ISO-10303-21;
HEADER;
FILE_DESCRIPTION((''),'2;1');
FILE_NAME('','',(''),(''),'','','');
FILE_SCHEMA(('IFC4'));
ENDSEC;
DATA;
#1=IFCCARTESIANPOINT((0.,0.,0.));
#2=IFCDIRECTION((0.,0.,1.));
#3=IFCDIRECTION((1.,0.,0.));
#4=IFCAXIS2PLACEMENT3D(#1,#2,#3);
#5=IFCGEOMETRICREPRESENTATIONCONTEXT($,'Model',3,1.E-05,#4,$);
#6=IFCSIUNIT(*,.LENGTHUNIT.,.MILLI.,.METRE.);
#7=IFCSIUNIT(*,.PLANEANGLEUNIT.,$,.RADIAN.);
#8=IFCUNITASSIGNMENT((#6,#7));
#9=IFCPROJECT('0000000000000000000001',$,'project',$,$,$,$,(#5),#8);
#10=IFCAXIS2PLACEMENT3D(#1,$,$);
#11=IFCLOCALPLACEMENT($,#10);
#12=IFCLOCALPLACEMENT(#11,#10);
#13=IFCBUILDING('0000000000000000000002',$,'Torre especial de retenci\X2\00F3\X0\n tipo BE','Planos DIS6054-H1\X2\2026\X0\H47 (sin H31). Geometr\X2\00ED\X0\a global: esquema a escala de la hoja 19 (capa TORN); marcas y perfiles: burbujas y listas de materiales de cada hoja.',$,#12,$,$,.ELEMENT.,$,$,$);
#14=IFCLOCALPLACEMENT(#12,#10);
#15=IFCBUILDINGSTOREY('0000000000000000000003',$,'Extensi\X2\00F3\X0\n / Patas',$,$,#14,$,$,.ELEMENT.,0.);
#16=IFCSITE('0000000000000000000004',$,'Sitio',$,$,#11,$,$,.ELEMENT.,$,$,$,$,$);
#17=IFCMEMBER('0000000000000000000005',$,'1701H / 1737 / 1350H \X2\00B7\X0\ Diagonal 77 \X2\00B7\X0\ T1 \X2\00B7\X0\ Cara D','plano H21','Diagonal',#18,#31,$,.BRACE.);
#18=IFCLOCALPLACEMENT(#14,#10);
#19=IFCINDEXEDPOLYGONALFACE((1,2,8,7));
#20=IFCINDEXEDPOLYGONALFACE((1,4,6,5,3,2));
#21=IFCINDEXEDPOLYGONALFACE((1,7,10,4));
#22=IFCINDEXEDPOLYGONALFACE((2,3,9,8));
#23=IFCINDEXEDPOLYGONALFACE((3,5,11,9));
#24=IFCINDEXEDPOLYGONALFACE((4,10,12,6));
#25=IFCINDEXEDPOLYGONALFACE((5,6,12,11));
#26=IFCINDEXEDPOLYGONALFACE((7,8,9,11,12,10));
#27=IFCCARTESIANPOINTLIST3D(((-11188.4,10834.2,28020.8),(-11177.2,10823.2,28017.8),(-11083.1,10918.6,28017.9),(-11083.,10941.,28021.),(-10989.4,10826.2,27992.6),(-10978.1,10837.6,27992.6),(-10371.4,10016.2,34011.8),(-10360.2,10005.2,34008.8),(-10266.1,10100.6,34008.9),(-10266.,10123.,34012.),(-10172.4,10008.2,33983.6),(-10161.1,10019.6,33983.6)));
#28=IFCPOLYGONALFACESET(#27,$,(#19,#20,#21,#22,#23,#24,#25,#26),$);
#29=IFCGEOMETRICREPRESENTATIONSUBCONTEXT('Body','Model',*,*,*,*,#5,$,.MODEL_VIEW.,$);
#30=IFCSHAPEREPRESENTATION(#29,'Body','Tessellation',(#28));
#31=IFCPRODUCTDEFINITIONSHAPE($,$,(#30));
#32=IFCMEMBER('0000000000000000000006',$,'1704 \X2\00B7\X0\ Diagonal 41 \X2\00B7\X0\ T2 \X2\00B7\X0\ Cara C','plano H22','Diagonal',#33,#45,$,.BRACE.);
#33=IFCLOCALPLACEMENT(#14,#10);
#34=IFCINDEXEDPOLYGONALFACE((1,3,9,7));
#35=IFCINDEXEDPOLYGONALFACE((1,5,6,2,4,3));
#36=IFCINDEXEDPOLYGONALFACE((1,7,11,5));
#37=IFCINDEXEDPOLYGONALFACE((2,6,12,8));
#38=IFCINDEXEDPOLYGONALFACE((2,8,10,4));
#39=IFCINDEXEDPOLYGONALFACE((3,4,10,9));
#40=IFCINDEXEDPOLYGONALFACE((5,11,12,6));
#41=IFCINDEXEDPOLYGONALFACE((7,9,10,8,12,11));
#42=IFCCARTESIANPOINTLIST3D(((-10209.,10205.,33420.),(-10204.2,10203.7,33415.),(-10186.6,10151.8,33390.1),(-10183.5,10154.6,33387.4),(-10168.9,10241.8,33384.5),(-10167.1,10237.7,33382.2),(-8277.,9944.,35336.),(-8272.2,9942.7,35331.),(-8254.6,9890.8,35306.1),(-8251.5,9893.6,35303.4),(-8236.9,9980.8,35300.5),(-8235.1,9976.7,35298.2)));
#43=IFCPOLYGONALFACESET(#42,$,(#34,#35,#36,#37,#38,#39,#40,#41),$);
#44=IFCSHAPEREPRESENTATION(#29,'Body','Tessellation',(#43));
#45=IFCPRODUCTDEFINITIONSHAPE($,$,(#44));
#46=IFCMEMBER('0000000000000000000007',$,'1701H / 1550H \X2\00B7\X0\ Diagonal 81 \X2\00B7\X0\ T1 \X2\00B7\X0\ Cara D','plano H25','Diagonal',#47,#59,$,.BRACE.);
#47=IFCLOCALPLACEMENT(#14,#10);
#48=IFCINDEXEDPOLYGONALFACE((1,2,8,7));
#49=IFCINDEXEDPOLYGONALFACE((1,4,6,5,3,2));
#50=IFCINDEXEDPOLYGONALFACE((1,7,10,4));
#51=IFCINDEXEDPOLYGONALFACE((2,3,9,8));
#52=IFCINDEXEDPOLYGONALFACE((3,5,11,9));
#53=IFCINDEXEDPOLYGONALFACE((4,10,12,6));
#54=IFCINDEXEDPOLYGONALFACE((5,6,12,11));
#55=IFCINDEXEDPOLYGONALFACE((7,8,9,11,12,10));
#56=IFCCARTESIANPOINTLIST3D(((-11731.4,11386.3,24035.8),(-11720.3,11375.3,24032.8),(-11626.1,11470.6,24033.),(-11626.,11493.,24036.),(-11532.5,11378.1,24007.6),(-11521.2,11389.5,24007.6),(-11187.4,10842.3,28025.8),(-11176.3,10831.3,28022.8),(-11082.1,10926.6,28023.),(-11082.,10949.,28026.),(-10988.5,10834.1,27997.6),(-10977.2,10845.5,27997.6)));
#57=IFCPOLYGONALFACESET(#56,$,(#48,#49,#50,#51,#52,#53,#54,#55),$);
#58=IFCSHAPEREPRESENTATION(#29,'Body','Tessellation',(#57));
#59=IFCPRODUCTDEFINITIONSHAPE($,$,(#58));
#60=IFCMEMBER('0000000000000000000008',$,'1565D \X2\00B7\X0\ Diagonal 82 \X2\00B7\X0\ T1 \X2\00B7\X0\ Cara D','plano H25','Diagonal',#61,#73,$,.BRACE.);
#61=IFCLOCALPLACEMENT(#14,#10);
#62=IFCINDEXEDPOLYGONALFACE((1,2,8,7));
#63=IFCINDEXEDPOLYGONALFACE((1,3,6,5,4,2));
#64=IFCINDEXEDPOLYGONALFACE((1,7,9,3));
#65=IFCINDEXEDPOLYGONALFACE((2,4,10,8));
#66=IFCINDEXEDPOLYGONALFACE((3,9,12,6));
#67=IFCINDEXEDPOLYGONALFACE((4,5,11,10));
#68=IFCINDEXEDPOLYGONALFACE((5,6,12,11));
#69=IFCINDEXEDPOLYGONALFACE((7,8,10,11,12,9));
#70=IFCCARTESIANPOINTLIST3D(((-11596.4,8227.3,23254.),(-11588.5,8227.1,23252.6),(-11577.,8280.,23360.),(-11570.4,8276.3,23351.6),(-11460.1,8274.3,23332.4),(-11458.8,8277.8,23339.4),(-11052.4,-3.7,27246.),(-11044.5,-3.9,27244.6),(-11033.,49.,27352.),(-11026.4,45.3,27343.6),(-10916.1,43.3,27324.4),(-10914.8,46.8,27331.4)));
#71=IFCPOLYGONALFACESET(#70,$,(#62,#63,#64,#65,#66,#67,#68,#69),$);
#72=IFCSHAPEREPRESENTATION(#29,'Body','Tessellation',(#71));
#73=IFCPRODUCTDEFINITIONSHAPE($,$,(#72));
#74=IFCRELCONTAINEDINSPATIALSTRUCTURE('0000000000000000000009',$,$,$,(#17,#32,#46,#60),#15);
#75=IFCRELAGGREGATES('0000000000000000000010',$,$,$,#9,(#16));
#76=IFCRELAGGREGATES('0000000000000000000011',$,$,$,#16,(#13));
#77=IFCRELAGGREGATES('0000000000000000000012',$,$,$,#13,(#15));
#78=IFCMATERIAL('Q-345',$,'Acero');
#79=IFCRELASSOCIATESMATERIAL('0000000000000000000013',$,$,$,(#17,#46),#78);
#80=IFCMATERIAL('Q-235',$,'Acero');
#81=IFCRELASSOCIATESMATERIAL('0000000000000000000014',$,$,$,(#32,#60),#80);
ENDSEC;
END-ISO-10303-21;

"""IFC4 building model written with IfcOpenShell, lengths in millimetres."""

from ifc_helpers import new_model, si_unit, frame, frame_2d, origin, origin_with_axes, place, context, subcontext, project, spatial, l_section, extrude, material, element, save


model = new_model("IFC4")

# Units and contexts
model_context = context("Model", 3, precision=1e-05, world=origin_with_axes())
body_context = subcontext(model_context, "Body", "Model", "MODEL_VIEW")
ifc_project = project(units=[si_unit("LENGTHUNIT", "METRE", prefix="MILLI"), si_unit("PLANEANGLEUNIT", "RADIAN")], contexts=[model_context])

# Site, building, storey
site_placement = place(None, origin())
site = spatial("IfcSite", under=ifc_project, at=site_placement, Name="Sitio", CompositionType="ELEMENT")
building_placement = place(site_placement, origin())
building = spatial("IfcBuilding", under=site, at=building_placement, Name="Torre especial de retención tipo BE", Description="Planos DIS6054-H1…H47 (sin H31). Geometría global: esquema a escala de la hoja 19 (capa TORN); marcas y perfiles: burbujas y listas de materiales de cada hoja.", CompositionType="ELEMENT")
storey_placement = place(building_placement, origin())
storey = spatial("IfcBuildingStorey", under=building, at=storey_placement, Name="Extensión / Patas", CompositionType="ELEMENT", Elevation=0.0)

# Members
ifc_material_1 = material(Name="Q-235", Category="Acero")
ifc_material_2 = material(Name="Q-345", Category="Acero")
member_1_placement = place(storey_placement, frame((-10266.0, 10123.0, 34012.0), z_axis=(-0.133901, 0.134065, -0.981885), x_axis=(0.699136, -0.689426, -0.189475)))
element("IfcMember", 1, at=member_1_placement, inside=storey, material=ifc_material_2, Name="1701H / 1737 / 1350H · Diagonal 77 · T1 · Cara D", Description="plano H21", ObjectType="Diagonal", PredefinedType="BRACE", context=body_context, shape_type="SweptSolid", body=[
    extrude(l_section(Depth=150.0, Width=150.0, Thickness=16.0, at=frame_2d((75.0, 75.0))), None, (0.0, 0.0, 1.0), 6101.5),
])
member_2_placement = place(storey_placement, frame((-10209.0, 10205.0, 33420.0), z_axis=(0.706797, -0.095483, 0.700943), x_axis=(0.345055, -0.818452, -0.459427)))
element("IfcMember", 2, at=member_2_placement, inside=storey, material=ifc_material_1, Name="1704 · Diagonal 41 · T2 · Cara C", Description="plano H22", ObjectType="Diagonal", PredefinedType="BRACE", context=body_context, shape_type="SweptSolid", body=[
    extrude(l_section(Depth=65.0, Width=65.0, Thickness=5.0, at=frame_2d((32.5, 32.5))), None, (0.0, 0.0, 1.0), 2733.5),
])
member_3_placement = place(storey_placement, frame((-11082.0, 10949.0, 28026.0), z_axis=(-0.133875, 0.133875, -0.981914), x_axis=(0.698548, -0.690063, -0.189324)))
element("IfcMember", 3, at=member_3_placement, inside=storey, material=ifc_material_2, Name="1701H / 1550H · Diagonal 81 · T1 · Cara D", Description="plano H25", ObjectType="Diagonal", PredefinedType="BRACE", context=body_context, shape_type="SweptSolid", body=[
    extrude(l_section(Depth=150.0, Width=150.0, Thickness=16.0, at=frame_2d((75.0, 75.0))), None, (0.0, 0.0, 1.0), 4063.5),
])
member_4_placement = place(storey_placement, frame((-11033.0, 49.0, 27352.0), z_axis=(-0.059362, 0.898175, -0.435611), x_axis=(0.985034, -0.018033, -0.171415)))
element("IfcMember", 4, at=member_4_placement, inside=storey, material=ifc_material_1, Name="1565D · Diagonal 82 · T1 · Cara D", Description="plano H25", ObjectType="Diagonal", PredefinedType="BRACE", context=body_context, shape_type="SweptSolid", body=[
    extrude(l_section(Depth=120.0, Width=120.0, Thickness=8.0, at=frame_2d((60.0, 60.0))), None, (0.0, 0.0, 1.0), 9164.1),
])

save(model, "model.ifc")
